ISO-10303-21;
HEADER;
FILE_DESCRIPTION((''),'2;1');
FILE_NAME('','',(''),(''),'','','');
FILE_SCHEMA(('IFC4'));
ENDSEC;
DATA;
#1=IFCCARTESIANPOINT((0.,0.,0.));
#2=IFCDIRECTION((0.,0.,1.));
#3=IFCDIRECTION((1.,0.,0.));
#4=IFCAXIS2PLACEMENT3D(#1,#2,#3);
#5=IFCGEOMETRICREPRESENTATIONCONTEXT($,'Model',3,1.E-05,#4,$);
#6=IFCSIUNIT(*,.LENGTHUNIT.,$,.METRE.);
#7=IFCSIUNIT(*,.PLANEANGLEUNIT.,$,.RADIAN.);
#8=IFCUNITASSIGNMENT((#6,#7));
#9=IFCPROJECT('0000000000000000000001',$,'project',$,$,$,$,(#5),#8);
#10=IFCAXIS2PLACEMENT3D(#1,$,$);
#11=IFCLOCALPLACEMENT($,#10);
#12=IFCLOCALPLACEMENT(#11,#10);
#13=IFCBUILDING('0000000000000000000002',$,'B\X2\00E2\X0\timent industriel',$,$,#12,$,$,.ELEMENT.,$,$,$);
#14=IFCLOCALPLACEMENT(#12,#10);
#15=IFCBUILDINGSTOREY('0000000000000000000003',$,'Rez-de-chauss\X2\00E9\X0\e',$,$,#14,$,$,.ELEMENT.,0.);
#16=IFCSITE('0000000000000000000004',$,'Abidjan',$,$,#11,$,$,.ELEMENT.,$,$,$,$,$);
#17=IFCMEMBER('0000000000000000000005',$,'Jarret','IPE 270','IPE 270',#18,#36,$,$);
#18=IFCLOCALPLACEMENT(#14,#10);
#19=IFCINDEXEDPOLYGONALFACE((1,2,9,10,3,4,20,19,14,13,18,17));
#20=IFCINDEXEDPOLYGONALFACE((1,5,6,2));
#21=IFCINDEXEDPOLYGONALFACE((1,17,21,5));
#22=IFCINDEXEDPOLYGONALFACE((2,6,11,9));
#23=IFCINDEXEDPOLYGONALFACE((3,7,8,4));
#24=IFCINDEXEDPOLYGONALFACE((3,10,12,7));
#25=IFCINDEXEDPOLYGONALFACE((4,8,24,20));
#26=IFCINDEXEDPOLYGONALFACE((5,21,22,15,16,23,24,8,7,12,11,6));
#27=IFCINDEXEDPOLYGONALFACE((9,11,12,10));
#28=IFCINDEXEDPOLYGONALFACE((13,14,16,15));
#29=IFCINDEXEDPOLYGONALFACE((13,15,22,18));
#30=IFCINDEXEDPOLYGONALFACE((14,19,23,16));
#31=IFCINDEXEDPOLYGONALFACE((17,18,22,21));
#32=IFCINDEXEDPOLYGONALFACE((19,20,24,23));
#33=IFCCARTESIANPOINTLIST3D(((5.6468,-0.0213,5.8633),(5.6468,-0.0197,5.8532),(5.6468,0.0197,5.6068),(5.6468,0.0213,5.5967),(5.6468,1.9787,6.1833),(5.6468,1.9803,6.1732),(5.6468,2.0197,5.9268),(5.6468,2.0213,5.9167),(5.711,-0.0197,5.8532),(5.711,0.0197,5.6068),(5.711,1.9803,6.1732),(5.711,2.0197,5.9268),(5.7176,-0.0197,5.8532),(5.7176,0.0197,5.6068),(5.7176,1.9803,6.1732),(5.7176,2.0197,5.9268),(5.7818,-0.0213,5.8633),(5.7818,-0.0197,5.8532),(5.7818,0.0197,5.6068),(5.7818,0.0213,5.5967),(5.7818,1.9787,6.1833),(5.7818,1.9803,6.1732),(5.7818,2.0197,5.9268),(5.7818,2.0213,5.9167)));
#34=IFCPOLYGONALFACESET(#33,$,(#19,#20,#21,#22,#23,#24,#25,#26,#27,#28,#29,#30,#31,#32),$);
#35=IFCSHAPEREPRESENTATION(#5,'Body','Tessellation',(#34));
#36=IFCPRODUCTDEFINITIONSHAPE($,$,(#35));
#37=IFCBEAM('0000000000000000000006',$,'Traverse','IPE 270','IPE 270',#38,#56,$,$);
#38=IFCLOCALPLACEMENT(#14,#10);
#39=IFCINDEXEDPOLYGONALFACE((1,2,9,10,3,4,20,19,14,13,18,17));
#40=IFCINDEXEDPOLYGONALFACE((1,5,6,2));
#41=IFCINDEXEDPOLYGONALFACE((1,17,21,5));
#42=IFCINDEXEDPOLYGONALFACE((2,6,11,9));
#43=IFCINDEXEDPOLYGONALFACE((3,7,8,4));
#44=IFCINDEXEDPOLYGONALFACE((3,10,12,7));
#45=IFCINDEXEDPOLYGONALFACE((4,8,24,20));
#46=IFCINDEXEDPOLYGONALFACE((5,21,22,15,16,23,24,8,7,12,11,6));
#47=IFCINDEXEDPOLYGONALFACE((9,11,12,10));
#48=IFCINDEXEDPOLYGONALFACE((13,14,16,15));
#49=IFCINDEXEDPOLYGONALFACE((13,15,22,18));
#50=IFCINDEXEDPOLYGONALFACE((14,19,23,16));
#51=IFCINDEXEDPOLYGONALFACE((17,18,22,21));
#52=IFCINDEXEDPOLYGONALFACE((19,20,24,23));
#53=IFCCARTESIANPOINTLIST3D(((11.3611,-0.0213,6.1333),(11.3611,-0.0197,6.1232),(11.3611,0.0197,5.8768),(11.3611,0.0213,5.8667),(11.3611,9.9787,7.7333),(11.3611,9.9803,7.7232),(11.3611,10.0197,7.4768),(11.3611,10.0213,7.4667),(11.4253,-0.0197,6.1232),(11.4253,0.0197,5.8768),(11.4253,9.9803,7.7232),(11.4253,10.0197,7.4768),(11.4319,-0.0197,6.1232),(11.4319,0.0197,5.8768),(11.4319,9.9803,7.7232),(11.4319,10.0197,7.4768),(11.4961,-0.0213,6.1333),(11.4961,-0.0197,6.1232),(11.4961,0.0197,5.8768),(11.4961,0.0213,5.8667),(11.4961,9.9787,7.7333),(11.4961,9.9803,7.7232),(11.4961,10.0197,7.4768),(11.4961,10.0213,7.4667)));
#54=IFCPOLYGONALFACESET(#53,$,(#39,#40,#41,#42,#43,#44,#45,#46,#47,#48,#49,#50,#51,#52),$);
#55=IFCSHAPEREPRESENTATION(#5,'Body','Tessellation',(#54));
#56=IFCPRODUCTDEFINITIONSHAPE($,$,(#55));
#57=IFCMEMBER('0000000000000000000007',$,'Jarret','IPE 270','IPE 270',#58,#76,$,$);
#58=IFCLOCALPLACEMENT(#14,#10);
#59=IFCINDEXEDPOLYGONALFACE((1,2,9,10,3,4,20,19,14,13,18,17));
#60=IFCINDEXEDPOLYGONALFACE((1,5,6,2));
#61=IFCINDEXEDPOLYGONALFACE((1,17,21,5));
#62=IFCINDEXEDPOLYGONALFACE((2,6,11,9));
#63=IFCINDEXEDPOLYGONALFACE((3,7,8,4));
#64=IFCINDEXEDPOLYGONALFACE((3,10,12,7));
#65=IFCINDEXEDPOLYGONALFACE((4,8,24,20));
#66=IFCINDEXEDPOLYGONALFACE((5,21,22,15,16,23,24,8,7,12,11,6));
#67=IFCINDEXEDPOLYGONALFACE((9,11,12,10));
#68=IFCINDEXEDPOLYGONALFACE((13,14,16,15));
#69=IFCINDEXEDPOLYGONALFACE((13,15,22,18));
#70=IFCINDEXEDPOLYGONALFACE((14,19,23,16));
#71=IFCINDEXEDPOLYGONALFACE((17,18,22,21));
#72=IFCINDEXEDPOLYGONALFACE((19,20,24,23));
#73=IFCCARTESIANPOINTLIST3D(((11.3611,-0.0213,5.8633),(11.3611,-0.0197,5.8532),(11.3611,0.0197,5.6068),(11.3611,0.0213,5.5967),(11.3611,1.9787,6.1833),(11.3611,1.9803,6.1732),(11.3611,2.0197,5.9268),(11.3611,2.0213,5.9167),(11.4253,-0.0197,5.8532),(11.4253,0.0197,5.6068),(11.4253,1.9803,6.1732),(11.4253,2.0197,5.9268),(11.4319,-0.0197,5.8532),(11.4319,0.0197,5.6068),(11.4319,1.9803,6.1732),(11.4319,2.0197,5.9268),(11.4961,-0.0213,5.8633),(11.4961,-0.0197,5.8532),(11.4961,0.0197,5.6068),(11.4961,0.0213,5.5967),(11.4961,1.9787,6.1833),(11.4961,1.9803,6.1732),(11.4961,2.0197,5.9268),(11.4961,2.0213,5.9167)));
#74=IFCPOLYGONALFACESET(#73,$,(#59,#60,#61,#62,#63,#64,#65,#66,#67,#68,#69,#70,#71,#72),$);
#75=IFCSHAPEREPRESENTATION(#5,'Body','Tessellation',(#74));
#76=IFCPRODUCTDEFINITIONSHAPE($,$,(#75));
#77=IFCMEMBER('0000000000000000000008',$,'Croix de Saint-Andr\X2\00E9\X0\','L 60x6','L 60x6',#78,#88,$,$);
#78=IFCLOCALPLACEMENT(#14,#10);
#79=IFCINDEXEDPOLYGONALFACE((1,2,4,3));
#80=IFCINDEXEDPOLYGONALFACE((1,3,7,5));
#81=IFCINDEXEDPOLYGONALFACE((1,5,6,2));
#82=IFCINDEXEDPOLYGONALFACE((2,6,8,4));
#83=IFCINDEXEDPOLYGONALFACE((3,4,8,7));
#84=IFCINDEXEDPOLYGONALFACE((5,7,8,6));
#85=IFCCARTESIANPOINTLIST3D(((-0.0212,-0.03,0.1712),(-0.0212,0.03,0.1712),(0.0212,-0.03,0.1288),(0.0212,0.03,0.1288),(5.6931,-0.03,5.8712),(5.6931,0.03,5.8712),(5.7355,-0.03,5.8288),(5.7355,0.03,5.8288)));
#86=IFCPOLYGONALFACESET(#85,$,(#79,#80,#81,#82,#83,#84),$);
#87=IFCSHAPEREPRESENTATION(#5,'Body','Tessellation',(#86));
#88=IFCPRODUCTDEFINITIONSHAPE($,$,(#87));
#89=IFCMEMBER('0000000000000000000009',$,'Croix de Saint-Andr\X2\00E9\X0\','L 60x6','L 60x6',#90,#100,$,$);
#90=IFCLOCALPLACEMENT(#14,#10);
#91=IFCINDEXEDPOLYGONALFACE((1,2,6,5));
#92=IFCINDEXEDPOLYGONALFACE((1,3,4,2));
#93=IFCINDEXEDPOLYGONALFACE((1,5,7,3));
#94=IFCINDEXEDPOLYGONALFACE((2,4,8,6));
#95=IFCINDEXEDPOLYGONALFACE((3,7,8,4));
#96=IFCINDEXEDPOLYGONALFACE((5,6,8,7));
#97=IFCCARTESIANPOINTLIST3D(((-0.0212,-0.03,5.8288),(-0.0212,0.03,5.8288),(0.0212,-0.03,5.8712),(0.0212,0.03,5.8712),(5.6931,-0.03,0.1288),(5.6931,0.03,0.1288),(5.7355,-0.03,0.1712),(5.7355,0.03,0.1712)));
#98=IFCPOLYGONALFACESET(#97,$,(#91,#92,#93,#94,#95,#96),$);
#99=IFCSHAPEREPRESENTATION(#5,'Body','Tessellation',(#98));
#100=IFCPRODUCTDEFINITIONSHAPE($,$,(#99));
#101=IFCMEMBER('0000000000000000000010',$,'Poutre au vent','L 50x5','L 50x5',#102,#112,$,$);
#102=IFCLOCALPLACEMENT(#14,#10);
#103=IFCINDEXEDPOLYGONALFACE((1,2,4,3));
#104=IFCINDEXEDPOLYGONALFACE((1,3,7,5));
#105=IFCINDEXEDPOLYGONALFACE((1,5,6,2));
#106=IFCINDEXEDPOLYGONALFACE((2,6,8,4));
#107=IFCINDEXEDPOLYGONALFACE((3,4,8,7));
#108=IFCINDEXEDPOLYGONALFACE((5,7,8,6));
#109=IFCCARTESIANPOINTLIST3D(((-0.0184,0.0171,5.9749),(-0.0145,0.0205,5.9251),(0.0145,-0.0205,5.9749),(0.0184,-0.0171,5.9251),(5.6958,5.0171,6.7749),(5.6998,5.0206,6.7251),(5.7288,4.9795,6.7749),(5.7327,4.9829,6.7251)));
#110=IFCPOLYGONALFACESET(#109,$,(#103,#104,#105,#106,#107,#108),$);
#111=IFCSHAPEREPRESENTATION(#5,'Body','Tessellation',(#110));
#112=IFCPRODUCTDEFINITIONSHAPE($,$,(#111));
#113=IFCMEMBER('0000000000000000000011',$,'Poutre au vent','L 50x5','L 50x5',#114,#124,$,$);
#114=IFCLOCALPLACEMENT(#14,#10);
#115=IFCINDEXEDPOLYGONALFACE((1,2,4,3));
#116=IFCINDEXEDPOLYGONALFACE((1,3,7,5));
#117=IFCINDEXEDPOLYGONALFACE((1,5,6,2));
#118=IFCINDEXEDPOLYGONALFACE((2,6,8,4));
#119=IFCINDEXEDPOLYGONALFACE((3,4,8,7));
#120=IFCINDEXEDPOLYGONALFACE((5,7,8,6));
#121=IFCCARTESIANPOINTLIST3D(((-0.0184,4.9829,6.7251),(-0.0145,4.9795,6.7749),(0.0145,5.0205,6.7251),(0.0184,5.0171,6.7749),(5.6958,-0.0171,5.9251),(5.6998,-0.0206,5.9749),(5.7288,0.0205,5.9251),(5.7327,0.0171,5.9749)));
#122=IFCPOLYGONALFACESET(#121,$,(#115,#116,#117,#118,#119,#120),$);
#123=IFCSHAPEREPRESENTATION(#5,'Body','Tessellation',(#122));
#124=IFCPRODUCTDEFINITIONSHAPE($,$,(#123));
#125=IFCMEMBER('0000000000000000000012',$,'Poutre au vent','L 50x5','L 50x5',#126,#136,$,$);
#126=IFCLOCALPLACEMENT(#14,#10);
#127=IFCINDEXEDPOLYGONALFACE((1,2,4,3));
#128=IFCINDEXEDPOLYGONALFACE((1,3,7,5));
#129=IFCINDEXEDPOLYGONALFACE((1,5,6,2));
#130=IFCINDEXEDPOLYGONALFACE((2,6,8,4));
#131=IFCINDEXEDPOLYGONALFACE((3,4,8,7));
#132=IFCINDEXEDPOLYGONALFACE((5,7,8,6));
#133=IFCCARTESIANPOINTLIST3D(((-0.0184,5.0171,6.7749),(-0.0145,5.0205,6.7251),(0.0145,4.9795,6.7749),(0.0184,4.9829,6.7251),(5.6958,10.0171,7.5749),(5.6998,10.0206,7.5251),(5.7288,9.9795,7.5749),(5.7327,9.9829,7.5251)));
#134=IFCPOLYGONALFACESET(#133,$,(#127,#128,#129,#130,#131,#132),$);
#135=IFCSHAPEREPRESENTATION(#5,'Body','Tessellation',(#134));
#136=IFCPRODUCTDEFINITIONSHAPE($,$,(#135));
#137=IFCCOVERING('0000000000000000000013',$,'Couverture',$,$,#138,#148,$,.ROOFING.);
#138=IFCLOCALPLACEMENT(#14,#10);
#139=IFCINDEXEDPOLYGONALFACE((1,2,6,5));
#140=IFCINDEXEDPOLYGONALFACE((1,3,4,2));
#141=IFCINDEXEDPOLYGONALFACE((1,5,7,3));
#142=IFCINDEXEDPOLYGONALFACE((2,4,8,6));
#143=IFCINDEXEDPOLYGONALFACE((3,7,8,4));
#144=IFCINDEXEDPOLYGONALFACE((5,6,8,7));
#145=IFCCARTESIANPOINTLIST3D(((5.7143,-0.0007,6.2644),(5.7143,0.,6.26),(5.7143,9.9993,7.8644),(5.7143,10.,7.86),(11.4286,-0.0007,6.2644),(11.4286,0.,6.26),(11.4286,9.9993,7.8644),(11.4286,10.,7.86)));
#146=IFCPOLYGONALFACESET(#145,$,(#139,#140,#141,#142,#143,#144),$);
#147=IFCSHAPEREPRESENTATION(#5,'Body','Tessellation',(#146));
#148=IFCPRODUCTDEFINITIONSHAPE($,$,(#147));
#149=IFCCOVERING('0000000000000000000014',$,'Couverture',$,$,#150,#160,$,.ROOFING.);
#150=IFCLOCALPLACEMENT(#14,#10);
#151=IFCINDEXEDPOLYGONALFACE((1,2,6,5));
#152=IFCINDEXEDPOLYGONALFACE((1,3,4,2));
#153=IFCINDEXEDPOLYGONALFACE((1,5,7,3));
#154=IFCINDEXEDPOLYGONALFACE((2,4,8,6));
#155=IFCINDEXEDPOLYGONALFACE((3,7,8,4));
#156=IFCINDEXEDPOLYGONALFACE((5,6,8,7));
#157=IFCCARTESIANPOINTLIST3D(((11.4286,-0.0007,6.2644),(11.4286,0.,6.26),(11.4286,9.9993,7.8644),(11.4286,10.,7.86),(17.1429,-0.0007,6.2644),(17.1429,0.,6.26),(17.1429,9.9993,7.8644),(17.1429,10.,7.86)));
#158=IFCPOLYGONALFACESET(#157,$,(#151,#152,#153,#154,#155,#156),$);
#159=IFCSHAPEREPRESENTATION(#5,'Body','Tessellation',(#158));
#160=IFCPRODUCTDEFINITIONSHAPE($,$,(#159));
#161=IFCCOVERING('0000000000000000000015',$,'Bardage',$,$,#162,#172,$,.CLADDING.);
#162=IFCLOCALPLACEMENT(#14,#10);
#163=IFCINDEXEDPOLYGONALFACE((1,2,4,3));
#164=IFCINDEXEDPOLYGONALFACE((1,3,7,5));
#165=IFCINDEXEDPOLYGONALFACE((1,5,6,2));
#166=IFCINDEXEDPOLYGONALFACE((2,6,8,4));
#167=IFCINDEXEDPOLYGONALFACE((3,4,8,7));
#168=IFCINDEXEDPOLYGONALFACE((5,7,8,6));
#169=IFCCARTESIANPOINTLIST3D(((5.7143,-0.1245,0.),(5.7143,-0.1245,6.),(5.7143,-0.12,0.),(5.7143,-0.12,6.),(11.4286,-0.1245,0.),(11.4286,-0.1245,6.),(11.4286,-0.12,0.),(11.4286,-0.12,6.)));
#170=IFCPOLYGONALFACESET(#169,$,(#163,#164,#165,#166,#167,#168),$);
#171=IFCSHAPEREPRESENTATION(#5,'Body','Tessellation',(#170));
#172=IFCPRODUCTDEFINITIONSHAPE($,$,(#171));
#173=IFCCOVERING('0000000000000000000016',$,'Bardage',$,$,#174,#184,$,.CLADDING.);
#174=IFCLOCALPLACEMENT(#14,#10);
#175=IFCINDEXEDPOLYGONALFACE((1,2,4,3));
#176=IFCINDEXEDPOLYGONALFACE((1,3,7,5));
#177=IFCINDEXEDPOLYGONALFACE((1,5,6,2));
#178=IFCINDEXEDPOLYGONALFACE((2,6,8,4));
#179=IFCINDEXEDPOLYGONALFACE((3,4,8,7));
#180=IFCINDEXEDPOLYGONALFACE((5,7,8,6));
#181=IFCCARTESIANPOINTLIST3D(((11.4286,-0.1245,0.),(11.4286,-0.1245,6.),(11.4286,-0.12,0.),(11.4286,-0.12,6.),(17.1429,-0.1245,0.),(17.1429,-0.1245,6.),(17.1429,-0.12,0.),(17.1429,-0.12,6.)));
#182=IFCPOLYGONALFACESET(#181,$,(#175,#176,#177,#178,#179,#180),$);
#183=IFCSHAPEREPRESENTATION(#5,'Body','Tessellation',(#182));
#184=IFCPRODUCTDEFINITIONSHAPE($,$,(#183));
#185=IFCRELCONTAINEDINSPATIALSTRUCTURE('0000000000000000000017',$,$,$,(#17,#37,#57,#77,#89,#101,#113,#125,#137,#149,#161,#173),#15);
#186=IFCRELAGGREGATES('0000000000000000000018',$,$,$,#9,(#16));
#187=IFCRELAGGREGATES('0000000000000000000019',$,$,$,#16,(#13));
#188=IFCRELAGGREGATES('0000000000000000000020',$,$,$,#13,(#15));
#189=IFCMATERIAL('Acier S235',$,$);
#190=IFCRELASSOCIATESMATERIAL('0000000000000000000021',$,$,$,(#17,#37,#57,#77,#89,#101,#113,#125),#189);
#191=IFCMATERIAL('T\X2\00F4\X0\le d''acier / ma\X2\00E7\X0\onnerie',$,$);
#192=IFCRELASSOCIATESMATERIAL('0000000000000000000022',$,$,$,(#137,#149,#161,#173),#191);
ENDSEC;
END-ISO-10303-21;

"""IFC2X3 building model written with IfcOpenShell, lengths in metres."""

from ifc_helpers import new_model, si_unit, frame, origin, origin_with_axes, origin_2d, place, context, project, spatial, polyline, rectangle, i_section, outline, extrude, material, element, save


model = new_model("IFC2X3")

# Units and contexts
model_context = context("Model", 3, precision=1e-05, world=origin_with_axes())
ifc_project = project(units=[si_unit("LENGTHUNIT", "METRE"), si_unit("PLANEANGLEUNIT", "RADIAN")], contexts=[model_context])

# Site, building, storey
site_placement = place(None, origin())
site = spatial("IfcSite", under=ifc_project, at=site_placement, Name="Abidjan", CompositionType="ELEMENT")
building_placement = place(site_placement, origin())
building = spatial("IfcBuilding", under=site, at=building_placement, Name="Bâtiment industriel", CompositionType="ELEMENT")
storey_placement = place(building_placement, origin())
storey = spatial("IfcBuildingStorey", under=building, at=storey_placement, Name="Rez-de-chaussée", CompositionType="ELEMENT", Elevation=0.0)

# Shared definitions
ifc_material_1 = material(Name="Acier S235")

# Member
member_1_placement = place(storey_placement, frame((5.7143, 0.0, 5.73), z_axis=(0.0, 0.98744, 0.15799), x_axis=(1.0, 0.0, 0.0)))
element("IfcMember", 1, at=member_1_placement, inside=storey, material=ifc_material_1, Name="Jarret", Description="IPE 270", ObjectType="IPE 270", context=model_context, shape_type="SweptSolid", body=[
    extrude(i_section(OverallWidth=0.135, OverallDepth=0.27, WebThickness=0.0066, FlangeThickness=0.0102, at=origin_2d()), origin(), (0.0, 0.0, 1.0), 2.0254),
])

# Beam
beam_1_placement = place(storey_placement, frame((11.4286, 0.0, 6.0), z_axis=(0.0, 0.98744, 0.15799), x_axis=(1.0, 0.0, 0.0)))
element("IfcBeam", 2, at=beam_1_placement, inside=storey, material=ifc_material_1, Name="Traverse", Description="IPE 270", ObjectType="IPE 270", context=model_context, shape_type="SweptSolid", body=[
    extrude(i_section(OverallWidth=0.135, OverallDepth=0.27, WebThickness=0.0066, FlangeThickness=0.0102, at=origin_2d()), origin(), (0.0, 0.0, 1.0), 10.1272),
])

# Members
member_2_placement = place(storey_placement, frame((11.4286, 0.0, 5.73), z_axis=(0.0, 0.98744, 0.15799), x_axis=(1.0, 0.0, 0.0)))
element("IfcMember", 3, at=member_2_placement, inside=storey, material=ifc_material_1, Name="Jarret", Description="IPE 270", ObjectType="IPE 270", context=model_context, shape_type="SweptSolid", body=[
    extrude(i_section(OverallWidth=0.135, OverallDepth=0.27, WebThickness=0.0066, FlangeThickness=0.0102, at=origin_2d()), origin(), (0.0, 0.0, 1.0), 2.0254),
])
for number, where, z_axis, x_axis, name in (
    (4, (0.0, 0.0, 0.15), (0.70799, 0.0, 0.70622), (0.0, 1.0, 0.0), "Croix de Saint-André"),
    (5, (5.7143, 0.0, 0.15), (-0.70799, 0.0, 0.70622), (0.0, 1.0, 0.0), "Croix de Saint-André"),
):
    element("IfcMember", number, at=place(storey_placement, frame(where, z_axis=z_axis, x_axis=x_axis)), inside=storey, material=ifc_material_1, Name=name, Description="L 60x6", ObjectType="L 60x6", context=model_context, shape_type="SweptSolid", body=[
        extrude(rectangle(XDim=0.06, YDim=0.06, at=origin_2d()), origin(), (0.0, 0.0, 1.0), 8.0711),
    ])
for number, where, z_axis, x_axis, name in (
    (6, (0.0, 0.0, 5.95), (0.74843, 0.65488, 0.10478), (-0.07886, -0.069, 0.9945), "Poutre au vent"),
    (7, (0.0, 5.0, 6.75), (0.74843, -0.65488, -0.10478), (0.07886, -0.069, 0.9945), "Poutre au vent"),
    (8, (0.0, 5.0, 6.75), (0.74843, 0.65488, 0.10478), (-0.07886, -0.069, 0.9945), "Poutre au vent"),
):
    element("IfcMember", number, at=place(storey_placement, frame(where, z_axis=z_axis, x_axis=x_axis)), inside=storey, material=ifc_material_1, Name=name, Description="L 50x5", ObjectType="L 50x5", context=model_context, shape_type="SweptSolid", body=[
        extrude(rectangle(XDim=0.05, YDim=0.05, at=origin_2d()), origin(), (0.0, 0.0, 1.0), 7.635),
    ])

# Coverings
ifc_material_2 = material(Name="Tôle d'acier / maçonnerie")
for number, where, z_axis, x_axis, name in (
    (9, (5.7143, 0.0, 6.26), (0.0, -0.15799, 0.98744), (1.0, 0.0, 0.0), "Couverture"),
    (10, (11.4286, 0.0, 6.26), (0.0, -0.15799, 0.98744), (1.0, 0.0, 0.0), "Couverture"),
):
    element("IfcCovering", number, at=place(storey_placement, frame(where, z_axis=z_axis, x_axis=x_axis)), inside=storey, material=ifc_material_2, Name=name, PredefinedType="ROOFING", context=model_context, shape_type="SweptSolid", body=[
        extrude(outline(polyline([(0.0, 0.0), (5.7143, 0.0), (5.7143, 10.1272), (0.0, 10.1272), (0.0, 0.0)])), origin(), (0.0, 0.0, 1.0), 0.0045),
    ])
for number, where, z_axis, x_axis, name in (
    (11, (5.7143, -0.12, 0.0), (0.0, -1.0, 0.0), (1.0, 0.0, 0.0), "Bardage"),
    (12, (11.4286, -0.12, 0.0), (0.0, -1.0, 0.0), (1.0, 0.0, 0.0), "Bardage"),
):
    element("IfcCovering", number, at=place(storey_placement, frame(where, z_axis=z_axis, x_axis=x_axis)), inside=storey, material=ifc_material_2, Name=name, PredefinedType="CLADDING", context=model_context, shape_type="SweptSolid", body=[
        extrude(outline(polyline([(0.0, 0.0), (5.7143, 0.0), (5.7143, 6.0), (0.0, 6.0), (0.0, 0.0)])), origin(), (0.0, 0.0, 1.0), 0.0045),
    ])

save(model, "model.ifc")
